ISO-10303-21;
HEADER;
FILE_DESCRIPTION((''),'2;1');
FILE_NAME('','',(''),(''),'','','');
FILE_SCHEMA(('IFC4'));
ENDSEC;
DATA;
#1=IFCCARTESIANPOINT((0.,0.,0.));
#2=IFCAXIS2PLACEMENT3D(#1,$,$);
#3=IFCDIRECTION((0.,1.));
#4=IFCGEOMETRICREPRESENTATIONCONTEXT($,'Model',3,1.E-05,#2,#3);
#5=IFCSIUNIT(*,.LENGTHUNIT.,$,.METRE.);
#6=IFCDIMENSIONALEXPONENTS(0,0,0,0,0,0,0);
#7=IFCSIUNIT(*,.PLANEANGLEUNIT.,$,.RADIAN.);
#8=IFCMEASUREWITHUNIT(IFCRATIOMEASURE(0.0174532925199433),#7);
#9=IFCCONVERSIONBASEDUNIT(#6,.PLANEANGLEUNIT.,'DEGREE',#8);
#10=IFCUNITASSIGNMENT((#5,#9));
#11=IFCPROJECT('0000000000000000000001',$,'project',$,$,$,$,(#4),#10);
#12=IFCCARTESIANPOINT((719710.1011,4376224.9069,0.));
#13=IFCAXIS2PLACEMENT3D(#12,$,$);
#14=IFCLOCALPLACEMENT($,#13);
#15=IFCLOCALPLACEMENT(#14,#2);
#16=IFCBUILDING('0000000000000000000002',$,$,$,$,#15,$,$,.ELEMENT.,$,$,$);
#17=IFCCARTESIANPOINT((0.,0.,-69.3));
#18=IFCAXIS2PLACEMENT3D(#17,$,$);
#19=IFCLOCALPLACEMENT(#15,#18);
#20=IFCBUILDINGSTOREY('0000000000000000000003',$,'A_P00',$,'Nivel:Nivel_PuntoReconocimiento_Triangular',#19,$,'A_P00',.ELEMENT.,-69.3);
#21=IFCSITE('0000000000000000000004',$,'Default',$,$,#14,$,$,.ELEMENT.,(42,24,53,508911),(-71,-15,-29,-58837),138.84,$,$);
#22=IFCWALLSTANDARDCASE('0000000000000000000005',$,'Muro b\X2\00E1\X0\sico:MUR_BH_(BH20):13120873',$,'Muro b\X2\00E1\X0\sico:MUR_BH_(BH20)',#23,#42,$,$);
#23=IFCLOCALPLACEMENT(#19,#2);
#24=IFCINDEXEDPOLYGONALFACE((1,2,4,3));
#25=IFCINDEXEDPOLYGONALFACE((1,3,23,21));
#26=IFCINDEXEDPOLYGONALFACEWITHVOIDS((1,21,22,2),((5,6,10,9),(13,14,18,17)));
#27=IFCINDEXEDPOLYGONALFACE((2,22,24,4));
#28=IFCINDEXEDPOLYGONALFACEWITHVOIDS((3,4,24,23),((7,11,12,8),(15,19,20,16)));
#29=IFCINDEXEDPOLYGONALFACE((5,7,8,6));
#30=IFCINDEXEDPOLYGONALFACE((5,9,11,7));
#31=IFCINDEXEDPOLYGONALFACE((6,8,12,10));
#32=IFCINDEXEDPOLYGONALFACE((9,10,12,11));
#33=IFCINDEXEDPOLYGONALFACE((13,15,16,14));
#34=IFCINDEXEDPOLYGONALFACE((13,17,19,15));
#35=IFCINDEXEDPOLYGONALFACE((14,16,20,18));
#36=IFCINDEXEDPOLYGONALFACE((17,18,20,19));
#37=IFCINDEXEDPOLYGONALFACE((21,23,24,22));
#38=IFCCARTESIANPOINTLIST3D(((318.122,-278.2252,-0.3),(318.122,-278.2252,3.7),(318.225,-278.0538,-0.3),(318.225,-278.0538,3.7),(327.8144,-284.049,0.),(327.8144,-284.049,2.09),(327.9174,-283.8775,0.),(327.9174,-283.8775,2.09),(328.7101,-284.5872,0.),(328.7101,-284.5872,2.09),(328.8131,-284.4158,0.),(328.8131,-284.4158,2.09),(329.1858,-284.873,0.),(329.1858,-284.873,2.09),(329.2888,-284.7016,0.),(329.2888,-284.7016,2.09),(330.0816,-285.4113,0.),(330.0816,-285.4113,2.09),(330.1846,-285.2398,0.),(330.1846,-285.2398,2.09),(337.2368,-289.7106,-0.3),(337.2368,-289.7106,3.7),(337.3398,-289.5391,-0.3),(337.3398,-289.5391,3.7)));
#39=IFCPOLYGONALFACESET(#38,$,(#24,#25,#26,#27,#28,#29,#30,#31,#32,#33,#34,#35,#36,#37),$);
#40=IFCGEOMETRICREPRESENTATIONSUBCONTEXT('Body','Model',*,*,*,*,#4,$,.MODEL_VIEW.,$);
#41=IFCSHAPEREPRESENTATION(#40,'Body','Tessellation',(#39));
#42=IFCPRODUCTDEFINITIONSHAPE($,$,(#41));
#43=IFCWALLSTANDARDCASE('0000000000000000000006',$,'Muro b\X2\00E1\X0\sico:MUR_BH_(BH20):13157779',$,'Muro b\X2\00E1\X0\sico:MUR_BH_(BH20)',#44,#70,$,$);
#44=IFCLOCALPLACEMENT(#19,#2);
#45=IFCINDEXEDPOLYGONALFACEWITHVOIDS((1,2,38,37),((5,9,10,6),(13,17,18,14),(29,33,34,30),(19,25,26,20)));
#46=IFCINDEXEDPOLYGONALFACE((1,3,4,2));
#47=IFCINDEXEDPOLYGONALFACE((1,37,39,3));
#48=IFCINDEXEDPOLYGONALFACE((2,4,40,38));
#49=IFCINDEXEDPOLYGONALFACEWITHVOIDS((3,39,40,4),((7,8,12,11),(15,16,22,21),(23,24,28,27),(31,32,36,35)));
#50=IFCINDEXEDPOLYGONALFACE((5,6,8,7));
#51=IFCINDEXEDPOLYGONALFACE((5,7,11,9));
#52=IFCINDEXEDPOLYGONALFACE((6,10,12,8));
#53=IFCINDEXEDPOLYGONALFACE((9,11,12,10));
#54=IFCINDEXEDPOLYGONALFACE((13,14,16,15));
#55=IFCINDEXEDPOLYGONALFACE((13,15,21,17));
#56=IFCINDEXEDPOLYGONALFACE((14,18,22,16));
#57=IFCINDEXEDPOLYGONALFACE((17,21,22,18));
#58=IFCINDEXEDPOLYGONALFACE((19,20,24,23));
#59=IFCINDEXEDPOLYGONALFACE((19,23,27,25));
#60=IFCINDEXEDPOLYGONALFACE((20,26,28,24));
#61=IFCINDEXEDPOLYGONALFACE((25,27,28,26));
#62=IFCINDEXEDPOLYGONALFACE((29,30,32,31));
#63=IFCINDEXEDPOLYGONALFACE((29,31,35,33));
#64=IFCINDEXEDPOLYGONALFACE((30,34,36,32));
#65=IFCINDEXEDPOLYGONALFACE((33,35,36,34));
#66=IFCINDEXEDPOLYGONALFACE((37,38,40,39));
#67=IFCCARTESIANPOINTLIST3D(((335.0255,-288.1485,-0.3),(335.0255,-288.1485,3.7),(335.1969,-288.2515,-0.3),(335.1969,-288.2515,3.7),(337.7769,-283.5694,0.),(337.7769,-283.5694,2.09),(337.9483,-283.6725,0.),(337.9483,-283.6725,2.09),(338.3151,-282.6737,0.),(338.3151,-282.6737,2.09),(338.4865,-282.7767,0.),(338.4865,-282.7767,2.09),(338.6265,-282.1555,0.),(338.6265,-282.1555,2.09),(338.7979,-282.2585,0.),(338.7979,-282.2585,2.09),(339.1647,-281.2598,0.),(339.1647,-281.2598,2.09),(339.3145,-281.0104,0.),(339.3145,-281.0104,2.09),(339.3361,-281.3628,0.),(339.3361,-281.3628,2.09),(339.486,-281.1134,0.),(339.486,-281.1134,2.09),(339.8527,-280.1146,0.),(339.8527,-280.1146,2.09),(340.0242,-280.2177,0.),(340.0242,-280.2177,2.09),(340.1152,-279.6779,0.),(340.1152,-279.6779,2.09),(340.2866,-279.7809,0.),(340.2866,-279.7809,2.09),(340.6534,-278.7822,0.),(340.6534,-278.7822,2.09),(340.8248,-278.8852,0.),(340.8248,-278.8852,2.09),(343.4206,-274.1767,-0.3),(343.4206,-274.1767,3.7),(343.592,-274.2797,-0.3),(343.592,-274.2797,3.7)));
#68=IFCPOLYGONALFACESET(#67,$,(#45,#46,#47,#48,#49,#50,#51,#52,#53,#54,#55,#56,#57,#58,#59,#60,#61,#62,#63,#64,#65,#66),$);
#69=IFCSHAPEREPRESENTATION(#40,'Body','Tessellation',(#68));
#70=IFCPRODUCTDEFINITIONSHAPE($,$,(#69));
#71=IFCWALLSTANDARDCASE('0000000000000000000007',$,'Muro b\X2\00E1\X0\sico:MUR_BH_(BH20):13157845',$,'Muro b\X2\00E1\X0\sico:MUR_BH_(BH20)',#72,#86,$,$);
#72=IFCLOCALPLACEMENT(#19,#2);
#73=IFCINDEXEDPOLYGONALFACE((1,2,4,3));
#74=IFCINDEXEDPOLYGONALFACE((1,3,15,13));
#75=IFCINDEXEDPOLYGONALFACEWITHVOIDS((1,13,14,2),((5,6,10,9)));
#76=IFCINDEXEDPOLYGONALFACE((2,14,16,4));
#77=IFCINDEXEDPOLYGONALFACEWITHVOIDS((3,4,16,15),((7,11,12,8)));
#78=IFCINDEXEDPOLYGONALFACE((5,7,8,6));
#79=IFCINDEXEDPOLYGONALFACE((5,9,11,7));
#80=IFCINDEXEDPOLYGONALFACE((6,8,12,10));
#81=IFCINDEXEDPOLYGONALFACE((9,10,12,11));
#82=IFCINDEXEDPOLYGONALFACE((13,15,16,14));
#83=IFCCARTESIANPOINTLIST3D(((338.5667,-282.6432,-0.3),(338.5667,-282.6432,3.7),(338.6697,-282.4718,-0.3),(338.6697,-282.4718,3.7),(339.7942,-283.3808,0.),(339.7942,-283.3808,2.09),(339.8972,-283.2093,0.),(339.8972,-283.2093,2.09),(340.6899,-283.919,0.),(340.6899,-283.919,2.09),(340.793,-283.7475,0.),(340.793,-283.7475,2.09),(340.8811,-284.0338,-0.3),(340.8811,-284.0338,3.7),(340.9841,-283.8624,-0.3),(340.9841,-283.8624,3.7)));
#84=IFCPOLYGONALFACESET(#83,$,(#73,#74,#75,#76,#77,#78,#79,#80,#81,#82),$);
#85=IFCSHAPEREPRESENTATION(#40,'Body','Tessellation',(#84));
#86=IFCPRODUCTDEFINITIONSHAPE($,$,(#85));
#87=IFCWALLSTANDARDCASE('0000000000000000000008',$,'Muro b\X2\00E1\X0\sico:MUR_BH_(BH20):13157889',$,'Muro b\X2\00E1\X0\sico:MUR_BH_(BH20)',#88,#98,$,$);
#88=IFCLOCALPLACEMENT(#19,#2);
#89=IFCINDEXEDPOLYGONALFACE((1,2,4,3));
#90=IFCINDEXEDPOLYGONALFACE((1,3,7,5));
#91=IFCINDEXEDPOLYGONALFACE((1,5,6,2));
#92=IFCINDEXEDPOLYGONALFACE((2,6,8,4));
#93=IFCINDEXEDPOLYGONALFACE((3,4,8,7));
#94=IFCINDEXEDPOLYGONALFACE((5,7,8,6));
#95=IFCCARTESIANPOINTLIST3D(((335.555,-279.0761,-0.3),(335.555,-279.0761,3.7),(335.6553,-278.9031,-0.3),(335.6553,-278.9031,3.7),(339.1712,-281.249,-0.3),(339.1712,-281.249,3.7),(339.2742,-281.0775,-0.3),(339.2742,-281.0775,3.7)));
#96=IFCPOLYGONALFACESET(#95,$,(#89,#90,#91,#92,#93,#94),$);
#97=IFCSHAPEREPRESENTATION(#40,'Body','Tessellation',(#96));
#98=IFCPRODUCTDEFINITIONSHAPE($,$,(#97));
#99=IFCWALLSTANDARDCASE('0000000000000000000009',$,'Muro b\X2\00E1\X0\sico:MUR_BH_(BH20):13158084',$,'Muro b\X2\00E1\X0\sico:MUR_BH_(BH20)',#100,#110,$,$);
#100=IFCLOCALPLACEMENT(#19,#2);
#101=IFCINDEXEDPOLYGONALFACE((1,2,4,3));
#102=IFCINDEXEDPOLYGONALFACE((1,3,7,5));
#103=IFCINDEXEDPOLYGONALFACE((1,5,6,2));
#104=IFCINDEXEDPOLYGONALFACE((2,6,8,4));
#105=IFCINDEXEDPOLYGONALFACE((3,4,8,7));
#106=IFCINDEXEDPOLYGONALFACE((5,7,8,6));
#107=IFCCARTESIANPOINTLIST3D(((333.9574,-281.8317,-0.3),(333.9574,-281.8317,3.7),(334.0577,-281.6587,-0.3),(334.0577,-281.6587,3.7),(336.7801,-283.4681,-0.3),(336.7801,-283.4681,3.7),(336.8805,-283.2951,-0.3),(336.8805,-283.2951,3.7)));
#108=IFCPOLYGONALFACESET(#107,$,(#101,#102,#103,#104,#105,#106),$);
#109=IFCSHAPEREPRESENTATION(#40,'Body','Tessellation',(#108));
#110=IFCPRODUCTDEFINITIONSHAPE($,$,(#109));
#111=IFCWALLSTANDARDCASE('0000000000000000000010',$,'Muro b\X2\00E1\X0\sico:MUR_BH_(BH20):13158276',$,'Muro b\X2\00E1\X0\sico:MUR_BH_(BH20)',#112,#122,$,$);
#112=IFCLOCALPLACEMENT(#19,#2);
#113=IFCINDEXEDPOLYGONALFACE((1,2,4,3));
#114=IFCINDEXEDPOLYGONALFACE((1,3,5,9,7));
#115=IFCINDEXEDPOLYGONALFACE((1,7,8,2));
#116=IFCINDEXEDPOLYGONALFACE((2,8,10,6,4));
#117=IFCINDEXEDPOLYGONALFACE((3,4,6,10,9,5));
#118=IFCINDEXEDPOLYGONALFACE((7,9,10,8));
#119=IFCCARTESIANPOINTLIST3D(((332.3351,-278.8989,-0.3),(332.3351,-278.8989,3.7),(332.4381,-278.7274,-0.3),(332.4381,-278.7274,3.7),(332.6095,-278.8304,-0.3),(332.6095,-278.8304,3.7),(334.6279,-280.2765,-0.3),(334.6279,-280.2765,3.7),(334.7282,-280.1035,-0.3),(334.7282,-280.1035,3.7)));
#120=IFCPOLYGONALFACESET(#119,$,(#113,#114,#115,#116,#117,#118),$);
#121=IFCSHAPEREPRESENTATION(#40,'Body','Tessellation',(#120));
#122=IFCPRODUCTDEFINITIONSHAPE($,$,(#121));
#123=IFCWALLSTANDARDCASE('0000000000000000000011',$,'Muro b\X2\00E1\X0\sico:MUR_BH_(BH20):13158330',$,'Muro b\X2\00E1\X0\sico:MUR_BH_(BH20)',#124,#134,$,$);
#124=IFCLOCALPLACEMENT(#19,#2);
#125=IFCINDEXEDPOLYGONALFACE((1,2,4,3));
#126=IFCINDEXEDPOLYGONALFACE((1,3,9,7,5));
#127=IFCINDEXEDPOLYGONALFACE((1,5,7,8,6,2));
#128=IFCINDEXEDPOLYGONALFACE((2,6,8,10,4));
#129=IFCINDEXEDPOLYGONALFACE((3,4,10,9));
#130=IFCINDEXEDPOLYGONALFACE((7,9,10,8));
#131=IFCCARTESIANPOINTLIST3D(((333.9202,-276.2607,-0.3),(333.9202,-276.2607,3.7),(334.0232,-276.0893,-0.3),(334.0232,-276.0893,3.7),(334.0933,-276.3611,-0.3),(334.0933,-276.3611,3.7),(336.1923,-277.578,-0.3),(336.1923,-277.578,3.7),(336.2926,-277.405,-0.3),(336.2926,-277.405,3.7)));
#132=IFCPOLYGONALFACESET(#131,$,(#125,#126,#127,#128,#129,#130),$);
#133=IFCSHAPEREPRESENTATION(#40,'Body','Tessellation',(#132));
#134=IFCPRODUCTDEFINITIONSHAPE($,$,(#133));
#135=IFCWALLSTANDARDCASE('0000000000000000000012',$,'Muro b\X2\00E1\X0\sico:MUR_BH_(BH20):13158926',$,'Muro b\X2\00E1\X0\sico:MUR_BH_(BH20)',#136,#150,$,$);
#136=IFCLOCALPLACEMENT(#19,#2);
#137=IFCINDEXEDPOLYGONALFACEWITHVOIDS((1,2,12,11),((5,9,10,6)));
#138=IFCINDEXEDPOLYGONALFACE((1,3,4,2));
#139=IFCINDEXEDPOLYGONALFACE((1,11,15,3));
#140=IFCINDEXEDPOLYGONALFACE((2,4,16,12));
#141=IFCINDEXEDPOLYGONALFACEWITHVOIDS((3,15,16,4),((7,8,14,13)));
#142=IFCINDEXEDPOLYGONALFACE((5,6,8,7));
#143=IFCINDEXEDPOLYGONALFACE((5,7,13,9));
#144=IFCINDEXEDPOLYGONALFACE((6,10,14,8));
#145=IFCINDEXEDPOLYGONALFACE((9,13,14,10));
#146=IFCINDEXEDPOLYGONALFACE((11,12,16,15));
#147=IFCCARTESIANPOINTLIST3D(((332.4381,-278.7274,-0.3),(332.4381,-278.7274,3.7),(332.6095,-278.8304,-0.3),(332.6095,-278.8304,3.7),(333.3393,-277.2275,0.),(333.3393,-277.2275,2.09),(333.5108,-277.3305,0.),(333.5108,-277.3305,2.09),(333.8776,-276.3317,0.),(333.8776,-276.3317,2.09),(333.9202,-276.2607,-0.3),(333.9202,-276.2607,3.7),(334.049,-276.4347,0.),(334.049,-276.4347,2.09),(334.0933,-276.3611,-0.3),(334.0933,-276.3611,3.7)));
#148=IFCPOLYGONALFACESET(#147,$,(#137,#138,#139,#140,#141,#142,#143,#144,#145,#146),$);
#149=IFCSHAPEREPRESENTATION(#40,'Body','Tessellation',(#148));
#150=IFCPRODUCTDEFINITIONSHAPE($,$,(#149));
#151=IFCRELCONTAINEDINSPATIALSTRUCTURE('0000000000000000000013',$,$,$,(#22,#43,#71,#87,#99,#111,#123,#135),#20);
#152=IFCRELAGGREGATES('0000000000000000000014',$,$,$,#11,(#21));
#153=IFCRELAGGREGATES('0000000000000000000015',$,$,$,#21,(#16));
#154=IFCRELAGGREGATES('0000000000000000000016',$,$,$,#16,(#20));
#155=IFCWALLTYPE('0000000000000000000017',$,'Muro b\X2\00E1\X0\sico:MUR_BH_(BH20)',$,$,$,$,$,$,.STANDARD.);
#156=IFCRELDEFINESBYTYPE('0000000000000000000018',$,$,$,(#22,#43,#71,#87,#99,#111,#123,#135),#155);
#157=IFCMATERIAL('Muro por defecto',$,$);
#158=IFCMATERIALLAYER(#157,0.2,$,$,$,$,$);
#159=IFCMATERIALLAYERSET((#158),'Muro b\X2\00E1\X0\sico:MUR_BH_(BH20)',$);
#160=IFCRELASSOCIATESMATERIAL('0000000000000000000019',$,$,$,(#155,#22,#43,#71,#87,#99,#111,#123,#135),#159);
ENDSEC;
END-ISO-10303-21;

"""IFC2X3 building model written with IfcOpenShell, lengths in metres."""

from ifc_helpers import new_model, entity, si_unit, converted_unit, direction, frame, frame_2d, origin, place, context, subcontext, project, spatial, polyline, rectangle, outline, extrude, material, layer, layer_set, layer_usage, type_object, element, save


model = new_model("IFC2X3")

# Units and contexts
model_context = context("Model", 3, precision=1e-05, world=origin(), true_north=direction((0.0, 1.0)))
body_context = subcontext(model_context, "Body", "Model", "MODEL_VIEW")
ifc_project = project(units=[si_unit("LENGTHUNIT", "METRE"), converted_unit("PLANEANGLEUNIT", "DEGREE", entity("IfcRatioMeasure", 0.0174532925199433), si_unit("PLANEANGLEUNIT", "RADIAN"), dimensions=[0, 0, 0, 0, 0, 0, 0])], contexts=[model_context])

# Site, building, storey
site_placement = place(None, frame((719710.1011, 4376224.9069, 0.0)))
site = spatial("IfcSite", under=ifc_project, at=site_placement, Name="Default", CompositionType="ELEMENT", RefLatitude=(42, 24, 53, 508911), RefLongitude=(-71, -15, -29, -58837), RefElevation=138.84)
building_placement = place(site_placement, origin())
building = spatial("IfcBuilding", under=site, at=building_placement, CompositionType="ELEMENT")
storey_placement = place(building_placement, frame((0.0, 0.0, -69.3)))
storey = spatial("IfcBuildingStorey", under=building, at=storey_placement, Name="A_P00", ObjectType="Nivel:Nivel_PuntoReconocimiento_Triangular", LongName="A_P00", CompositionType="ELEMENT", Elevation=-69.3)

# Walls, openings
ifc_material_1 = material(Name="Muro por defecto")
ifc_layer_1 = layer(ifc_material_1, 0.2)
ifc_layer_set_1 = layer_set([ifc_layer_1], Name="Muro básico:MUR_BH_(BH20)")
ifc_layer_usage_1 = layer_usage(ifc_layer_set_1, "AXIS2", "NEGATIVE", 0.1)
wall_type = type_object("IfcWallType", Name="Muro básico:MUR_BH_(BH20)", PredefinedType="STANDARD", material=ifc_layer_set_1)
wall_1_placement = place(storey_placement, frame((337.2883, -289.6249, -0.3), z_axis=(0.0, 0.0, 1.0), x_axis=(-0.857167, 0.515038, 0.0)))
wall_1 = element("IfcWallStandardCase", 1, at=wall_1_placement, inside=storey, type_object=wall_type, material=ifc_layer_usage_1, Name="Muro básico:MUR_BH_(BH20):13120873", ObjectType="Muro básico:MUR_BH_(BH20)", context=body_context, shape_type="SweptSolid", body=[
    extrude(rectangle(XDim=22.3, YDim=0.2, at=frame_2d((11.15, 0.0), x_axis=(-1.0, 0.0))), origin(), (0.0, 0.0, 1.0), 4.0),
])
opening_1_placement = place(wall_1_placement, frame((438.2804, -74.5406, 0.3), z_axis=(0.0, 0.0, 1.0), x_axis=(-0.857167, -0.515038, 0.0)))
element("IfcOpeningElement", 2, at=opening_1_placement, cuts=wall_1, ObjectType="Opening", context=body_context, shape_type="SweptSolid", body=[
    extrude(rectangle(XDim=2.09, YDim=1.045, at=frame_2d((0.0, 0.0), x_axis=(0.0, 1.0))), frame((328.3652, -284.1466, 1.045), z_axis=(-0.515038, -0.857167, 0.0), x_axis=(-0.857167, 0.515038, 0.0)), (0.0, 0.0, 1.0), 0.2),
])
opening_2_placement = place(wall_1_placement, frame((438.2804, -74.5406, 0.3), z_axis=(0.0, 0.0, 1.0), x_axis=(-0.857167, -0.515038, 0.0)))
element("IfcOpeningElement", 3, at=opening_2_placement, cuts=wall_1, ObjectType="Opening", context=body_context, shape_type="SweptSolid", body=[
    extrude(rectangle(XDim=2.09, YDim=1.045, at=frame_2d((0.0, 0.0), x_axis=(1.0, 0.0))), frame((329.7367, -284.9707, 1.045), z_axis=(-0.515038, -0.857167, 0.0), x_axis=(0.0, 0.0, -1.0)), (0.0, 0.0, 1.0), 0.2),
])
ifc_layer_usage_2 = layer_usage(ifc_layer_set_1, "AXIS2", "NEGATIVE", 0.1)
wall_2_placement = place(storey_placement, frame((335.1112, -288.2, -0.3), z_axis=(0.0, 0.0, 1.0), x_axis=(0.515038, 0.857167, 0.0)))
wall_2 = element("IfcWallStandardCase", 4, at=wall_2_placement, inside=storey, type_object=wall_type, material=ifc_layer_usage_2, Name="Muro básico:MUR_BH_(BH20):13157779", ObjectType="Muro básico:MUR_BH_(BH20)", context=body_context, shape_type="SweptSolid", body=[
    extrude(rectangle(XDim=16.3, YDim=0.2, at=frame_2d((8.15, 0.0), x_axis=(-1.0, 0.0))), origin(), (0.0, 0.0, 1.0), 4.0),
])
opening_3_placement = place(wall_2_placement, frame((74.4406, 435.6804, 0.3), z_axis=(0.0, 0.0, 1.0), x_axis=(0.515038, -0.857167, 0.0)))
element("IfcOpeningElement", 5, at=opening_3_placement, cuts=wall_2, ObjectType="Opening", context=body_context, shape_type="SweptSolid", body=[
    extrude(rectangle(XDim=2.09, YDim=1.045, at=frame_2d((0.0, 0.0), x_axis=(0.0, 1.0))), frame((339.7551, -280.6655, 1.045), z_axis=(-0.857167, 0.515038, 0.0), x_axis=(0.515038, 0.857167, 0.0)), (0.0, 0.0, 1.0), 0.2),
])
opening_4_placement = place(wall_2_placement, frame((74.4406, 435.6804, 0.3), z_axis=(0.0, 0.0, 1.0), x_axis=(0.515038, -0.857167, 0.0)))
element("IfcOpeningElement", 6, at=opening_4_placement, cuts=wall_2, ObjectType="Opening", context=body_context, shape_type="SweptSolid", body=[
    extrude(rectangle(XDim=2.09, YDim=1.045, at=frame_2d((0.0, 0.0), x_axis=(1.0, 0.0))), frame((339.067, -281.8106, 1.045), z_axis=(-0.857167, 0.515038, 0.0), x_axis=(0.0, 0.0, -1.0)), (0.0, 0.0, 1.0), 0.2),
])
opening_5_placement = place(wall_2_placement, frame((74.4406, 435.6804, 0.3), z_axis=(0.0, 0.0, 1.0), x_axis=(0.515038, -0.857167, 0.0)))
element("IfcOpeningElement", 7, at=opening_5_placement, cuts=wall_2, ObjectType="Opening", context=body_context, shape_type="SweptSolid", body=[
    extrude(rectangle(XDim=2.09, YDim=1.045, at=frame_2d((0.0, 0.0), x_axis=(0.0, 1.0))), frame((340.5557, -279.333, 1.045), z_axis=(-0.857167, 0.515038, 0.0), x_axis=(0.515038, 0.857167, 0.0)), (0.0, 0.0, 1.0), 0.2),
])
opening_6_placement = place(wall_2_placement, frame((74.4406, 435.6804, 0.3), z_axis=(0.0, 0.0, 1.0), x_axis=(0.515038, -0.857167, 0.0)))
element("IfcOpeningElement", 8, at=opening_6_placement, cuts=wall_2, ObjectType="Opening", context=body_context, shape_type="SweptSolid", body=[
    extrude(rectangle(XDim=2.09, YDim=1.045, at=frame_2d((0.0, 0.0), x_axis=(1.0, 0.0))), frame((338.2174, -283.2246, 1.045), z_axis=(-0.857167, 0.515038, 0.0), x_axis=(0.0, 0.0, -1.0)), (0.0, 0.0, 1.0), 0.2),
])

# Wall, opening
ifc_layer_usage_3 = layer_usage(ifc_layer_set_1, "AXIS2", "NEGATIVE", 0.1)
wall_3_placement = place(storey_placement, frame((338.6182, -282.5575, -0.3), z_axis=(0.0, 0.0, 1.0), x_axis=(0.857167, -0.515038, 0.0)))
wall_3 = element("IfcWallStandardCase", 9, at=wall_3_placement, inside=storey, type_object=wall_type, material=ifc_layer_usage_3, Name="Muro básico:MUR_BH_(BH20):13157845", ObjectType="Muro básico:MUR_BH_(BH20)", context=body_context, shape_type="SweptSolid", body=[
    extrude(rectangle(XDim=2.7, YDim=0.2, at=frame_2d((1.35, 0.0), x_axis=(-1.0, 0.0))), origin(), (0.0, 0.0, 1.0), 4.0),
])
opening_7_placement = place(wall_3_placement, frame((-435.7804, 67.7978, 0.3), z_axis=(0.0, 0.0, 1.0), x_axis=(0.857167, 0.515038, 0.0)))
element("IfcOpeningElement", 10, at=opening_7_placement, cuts=wall_3, ObjectType="Opening", context=body_context, shape_type="SweptSolid", body=[
    extrude(rectangle(XDim=2.09, YDim=1.045, at=frame_2d((0.0, 0.0), x_axis=(1.0, 0.0))), frame((340.2421, -283.6499, 1.045), z_axis=(0.515038, 0.857167, 0.0), x_axis=(0.0, 0.0, -1.0)), (0.0, 0.0, 1.0), 0.2),
])

# Walls
ifc_layer_usage_4 = layer_usage(ifc_layer_set_1, "AXIS2", "NEGATIVE", 0.1)
wall_4_placement = place(storey_placement, frame((339.2227, -281.1633, -0.3), z_axis=(0.0, 0.0, 1.0), x_axis=(-0.857167, 0.515038, 0.0)))
element("IfcWallStandardCase", 11, at=wall_4_placement, inside=storey, type_object=wall_type, material=ifc_layer_usage_4, Name="Muro básico:MUR_BH_(BH20):13157889", ObjectType="Muro básico:MUR_BH_(BH20)", context=body_context, shape_type="SweptSolid", body=[
    extrude(outline(polyline([(4.2219, -0.1), (4.2188, 0.1), (0.0, 0.1), (0.0, -0.1), (4.2219, -0.1)])), origin(), (0.0, 0.0, 1.0), 4.0),
])
ifc_layer_usage_5 = layer_usage(ifc_layer_set_1, "AXIS2", "NEGATIVE", 0.1)
wall_5_placement = place(storey_placement, frame((334.0076, -281.7452, -0.3), z_axis=(0.0, 0.0, 1.0), x_axis=(0.865126, -0.501555, 0.0)))
element("IfcWallStandardCase", 12, at=wall_5_placement, inside=storey, type_object=wall_type, material=ifc_layer_usage_5, Name="Muro básico:MUR_BH_(BH20):13158084", ObjectType="Muro básico:MUR_BH_(BH20)", context=body_context, shape_type="SweptSolid", body=[
    extrude(rectangle(XDim=3.2628, YDim=0.2, at=frame_2d((1.6314, 0.0), x_axis=(-1.0, 0.0))), origin(), (0.0, 0.0, 1.0), 4.0),
])
ifc_layer_usage_6 = layer_usage(ifc_layer_set_1, "AXIS2", "NEGATIVE", 0.1)
wall_6_placement = place(storey_placement, frame((332.3866, -278.8131, -0.3), z_axis=(0.0, 0.0, 1.0), x_axis=(0.857167, -0.515038, 0.0)))
element("IfcWallStandardCase", 13, at=wall_6_placement, inside=storey, type_object=wall_type, material=ifc_layer_usage_6, Name="Muro básico:MUR_BH_(BH20):13158276", ObjectType="Muro básico:MUR_BH_(BH20)", context=body_context, shape_type="SweptSolid", body=[
    extrude(outline(polyline([(2.6749, -0.1), (2.6717, 0.1), (0.2, 0.1), (0.0, 0.1), (0.0, -0.1), (2.6749, -0.1)])), origin(), (0.0, 0.0, 1.0), 4.0),
])

# Wall
ifc_layer_usage_7 = layer_usage(ifc_layer_set_1, "AXIS2", "NEGATIVE", 0.1)
wall_7_placement = place(storey_placement, frame((333.9704, -276.1742, -0.3), z_axis=(0.0, 0.0, 1.0), x_axis=(0.865126, -0.501555, 0.0)))
element("IfcWallStandardCase", 14, at=wall_7_placement, inside=storey, type_object=wall_type, material=ifc_layer_usage_7, Name="Muro básico:MUR_BH_(BH20):13158330", ObjectType="Muro básico:MUR_BH_(BH20)", context=body_context, shape_type="SweptSolid", body=[
    extrude(outline(polyline([(2.6263, -0.1), (2.6263, 0.1), (0.0031, 0.1), (0.0, -0.1), (0.2, -0.1), (2.6263, -0.1)])), origin(), (0.0, 0.0, 1.0), 4.0),
])

# Wall, opening
ifc_layer_usage_8 = layer_usage(ifc_layer_set_1, "AXIS2", "NEGATIVE", 0.1)
wall_8_placement = place(storey_placement, frame((334.0075, -276.3096, -0.3), z_axis=(0.0, 0.0, 1.0), x_axis=(-0.515038, -0.857167, 0.0)))
wall_8 = element("IfcWallStandardCase", 15, at=wall_8_placement, inside=storey, type_object=wall_type, material=ifc_layer_usage_8, Name="Muro básico:MUR_BH_(BH20):13158926", ObjectType="Muro básico:MUR_BH_(BH20)", context=body_context, shape_type="SweptSolid", body=[
    extrude(outline(polyline([(2.8808, -0.1), (2.8808, 0.1), (0.0, 0.1), (0.0031, -0.1), (2.8808, -0.1)])), origin(), (0.0, 0.0, 1.0), 4.0),
])
opening_8_placement = place(wall_8_placement, frame((-64.8169, -428.6103, 0.3), z_axis=(0.0, 0.0, 1.0), x_axis=(-0.515038, 0.857167, 0.0)))
element("IfcOpeningElement", 16, at=opening_8_placement, cuts=wall_8, ObjectType="Opening", context=body_context, shape_type="SweptSolid", body=[
    extrude(rectangle(XDim=2.09, YDim=1.045, at=frame_2d((0.0, 0.0), x_axis=(0.0, 1.0))), frame((333.6084, -276.7796, 1.045), z_axis=(0.857167, -0.515038, 0.0), x_axis=(-0.515038, -0.857167, 0.0)), (0.0, 0.0, 1.0), 0.2),
])

save(model, "model.ifc")
